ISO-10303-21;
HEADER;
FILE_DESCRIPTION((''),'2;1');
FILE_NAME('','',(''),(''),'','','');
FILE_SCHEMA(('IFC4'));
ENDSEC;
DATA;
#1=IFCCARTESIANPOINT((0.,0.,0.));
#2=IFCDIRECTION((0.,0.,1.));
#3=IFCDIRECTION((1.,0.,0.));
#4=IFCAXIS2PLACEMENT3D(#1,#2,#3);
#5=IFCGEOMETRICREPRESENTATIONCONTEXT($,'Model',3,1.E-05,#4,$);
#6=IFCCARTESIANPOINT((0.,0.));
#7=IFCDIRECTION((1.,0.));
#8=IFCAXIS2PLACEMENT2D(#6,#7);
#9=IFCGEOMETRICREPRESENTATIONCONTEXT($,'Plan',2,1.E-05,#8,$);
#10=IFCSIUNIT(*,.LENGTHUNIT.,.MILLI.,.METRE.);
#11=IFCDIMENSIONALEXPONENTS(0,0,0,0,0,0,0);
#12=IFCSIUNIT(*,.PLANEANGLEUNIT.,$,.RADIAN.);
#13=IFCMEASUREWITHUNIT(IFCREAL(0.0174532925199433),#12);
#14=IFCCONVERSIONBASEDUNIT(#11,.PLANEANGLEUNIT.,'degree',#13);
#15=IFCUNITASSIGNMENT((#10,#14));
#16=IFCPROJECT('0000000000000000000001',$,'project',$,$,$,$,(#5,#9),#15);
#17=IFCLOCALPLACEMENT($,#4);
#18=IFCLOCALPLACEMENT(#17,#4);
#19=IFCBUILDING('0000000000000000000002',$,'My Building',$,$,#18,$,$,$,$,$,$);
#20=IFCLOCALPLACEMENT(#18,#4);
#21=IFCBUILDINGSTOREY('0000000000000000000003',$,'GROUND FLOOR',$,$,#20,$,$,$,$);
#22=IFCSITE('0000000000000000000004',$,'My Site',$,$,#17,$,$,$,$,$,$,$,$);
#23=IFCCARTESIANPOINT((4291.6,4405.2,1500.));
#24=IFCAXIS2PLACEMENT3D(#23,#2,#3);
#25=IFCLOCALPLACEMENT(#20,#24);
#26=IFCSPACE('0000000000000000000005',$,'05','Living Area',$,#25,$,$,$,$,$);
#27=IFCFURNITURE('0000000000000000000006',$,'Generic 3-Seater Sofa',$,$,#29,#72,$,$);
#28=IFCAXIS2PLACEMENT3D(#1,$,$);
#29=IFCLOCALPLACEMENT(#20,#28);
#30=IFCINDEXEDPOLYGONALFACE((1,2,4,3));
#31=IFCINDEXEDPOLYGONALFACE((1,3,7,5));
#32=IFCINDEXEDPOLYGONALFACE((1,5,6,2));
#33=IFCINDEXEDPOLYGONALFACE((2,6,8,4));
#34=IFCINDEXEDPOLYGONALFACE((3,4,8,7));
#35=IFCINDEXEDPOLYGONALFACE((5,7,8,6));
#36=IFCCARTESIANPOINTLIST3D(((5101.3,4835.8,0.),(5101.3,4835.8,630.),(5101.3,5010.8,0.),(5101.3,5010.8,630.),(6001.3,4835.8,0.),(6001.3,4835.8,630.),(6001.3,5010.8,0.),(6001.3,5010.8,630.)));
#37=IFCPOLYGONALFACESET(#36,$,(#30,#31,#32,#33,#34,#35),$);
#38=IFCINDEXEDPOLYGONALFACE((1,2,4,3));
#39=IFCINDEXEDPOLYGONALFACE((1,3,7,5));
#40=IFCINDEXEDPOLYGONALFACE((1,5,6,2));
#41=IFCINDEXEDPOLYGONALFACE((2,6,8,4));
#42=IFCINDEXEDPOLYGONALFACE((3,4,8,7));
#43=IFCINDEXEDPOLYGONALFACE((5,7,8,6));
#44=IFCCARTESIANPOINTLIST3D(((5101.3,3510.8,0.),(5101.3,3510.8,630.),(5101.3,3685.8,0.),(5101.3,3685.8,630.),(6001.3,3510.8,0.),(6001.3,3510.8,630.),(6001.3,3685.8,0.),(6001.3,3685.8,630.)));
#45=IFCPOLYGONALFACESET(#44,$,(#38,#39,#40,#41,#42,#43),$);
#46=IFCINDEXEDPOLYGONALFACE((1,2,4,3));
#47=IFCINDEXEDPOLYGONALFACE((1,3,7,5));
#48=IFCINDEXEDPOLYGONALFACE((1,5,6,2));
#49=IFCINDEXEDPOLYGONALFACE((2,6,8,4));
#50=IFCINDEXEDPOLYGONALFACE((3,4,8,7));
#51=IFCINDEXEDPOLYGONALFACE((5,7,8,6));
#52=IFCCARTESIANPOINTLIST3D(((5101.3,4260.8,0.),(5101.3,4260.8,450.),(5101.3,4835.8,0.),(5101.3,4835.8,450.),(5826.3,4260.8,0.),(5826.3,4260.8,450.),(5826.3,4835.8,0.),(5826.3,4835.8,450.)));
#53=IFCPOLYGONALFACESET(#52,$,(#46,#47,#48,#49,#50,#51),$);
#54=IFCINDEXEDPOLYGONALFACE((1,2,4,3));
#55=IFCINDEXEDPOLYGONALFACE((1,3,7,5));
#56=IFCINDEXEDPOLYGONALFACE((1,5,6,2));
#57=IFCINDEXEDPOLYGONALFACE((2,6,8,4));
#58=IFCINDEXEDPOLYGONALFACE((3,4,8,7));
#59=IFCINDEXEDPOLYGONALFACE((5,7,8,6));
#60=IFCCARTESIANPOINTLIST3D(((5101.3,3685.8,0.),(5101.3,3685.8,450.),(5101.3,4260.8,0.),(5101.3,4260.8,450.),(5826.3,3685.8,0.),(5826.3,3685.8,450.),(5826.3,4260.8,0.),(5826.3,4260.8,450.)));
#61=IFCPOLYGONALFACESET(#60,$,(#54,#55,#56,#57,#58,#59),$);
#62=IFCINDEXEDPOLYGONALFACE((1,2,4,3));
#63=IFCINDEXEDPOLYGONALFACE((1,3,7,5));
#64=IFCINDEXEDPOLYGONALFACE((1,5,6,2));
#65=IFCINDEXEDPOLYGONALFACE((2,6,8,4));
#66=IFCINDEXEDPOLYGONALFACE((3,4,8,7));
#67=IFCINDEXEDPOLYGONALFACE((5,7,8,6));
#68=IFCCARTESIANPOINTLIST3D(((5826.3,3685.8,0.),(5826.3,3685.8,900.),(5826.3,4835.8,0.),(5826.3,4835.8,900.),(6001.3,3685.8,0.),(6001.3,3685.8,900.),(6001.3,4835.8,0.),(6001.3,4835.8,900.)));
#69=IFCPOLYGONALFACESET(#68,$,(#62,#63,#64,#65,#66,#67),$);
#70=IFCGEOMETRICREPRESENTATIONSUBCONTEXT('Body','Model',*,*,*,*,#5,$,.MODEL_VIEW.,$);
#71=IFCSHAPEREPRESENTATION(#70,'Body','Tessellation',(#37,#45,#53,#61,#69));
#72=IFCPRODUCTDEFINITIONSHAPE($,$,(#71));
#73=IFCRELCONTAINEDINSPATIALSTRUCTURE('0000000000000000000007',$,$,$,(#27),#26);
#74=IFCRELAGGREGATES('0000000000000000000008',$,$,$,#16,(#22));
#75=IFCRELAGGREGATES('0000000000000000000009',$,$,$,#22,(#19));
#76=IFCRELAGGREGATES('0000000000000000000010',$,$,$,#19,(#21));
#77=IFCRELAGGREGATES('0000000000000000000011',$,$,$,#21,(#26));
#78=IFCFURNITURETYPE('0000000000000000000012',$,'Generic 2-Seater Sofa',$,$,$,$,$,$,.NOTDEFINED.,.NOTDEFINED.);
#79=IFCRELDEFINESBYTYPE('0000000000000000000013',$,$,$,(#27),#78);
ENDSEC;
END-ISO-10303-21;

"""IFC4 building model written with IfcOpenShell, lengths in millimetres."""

from ifc_helpers import new_model, entity, si_unit, converted_unit, frame, origin_with_axes, origin_2d_with_axis, place, context, subcontext, project, spatial, line, indexed_curve, outline, extrude, shape, source, transform, mapped, type_object, type_shapes, element, save


model = new_model("IFC4")

# Units and contexts
model_context = context("Model", 3, precision=1e-05, world=origin_with_axes())
plan_context = context("Plan", 2, precision=1e-05, world=origin_2d_with_axis())
body_context_1 = subcontext(model_context, "Body", "Model", "MODEL_VIEW")
body_context_2 = subcontext(plan_context, "Body", "Plan", "PLAN_VIEW")
ifc_project = project(units=[si_unit("LENGTHUNIT", "METRE", prefix="MILLI"), converted_unit("PLANEANGLEUNIT", "degree", entity("IfcReal", 0.0174532925199433), si_unit("PLANEANGLEUNIT", "RADIAN"), dimensions=[0, 0, 0, 0, 0, 0, 0])], contexts=[model_context, plan_context])

# Site, building, storey
site_placement = place(None, origin_with_axes())
site = spatial("IfcSite", under=ifc_project, at=site_placement, Name="My Site")
building_placement = place(site_placement, origin_with_axes())
building = spatial("IfcBuilding", under=site, at=building_placement, Name="My Building")
storey_placement = place(building_placement, origin_with_axes())
storey = spatial("IfcBuildingStorey", under=building, at=storey_placement, Name="GROUND FLOOR")

# Shared definitions
space_1_placement = place(storey_placement, frame((4291.6, 4405.2, 1500.0), z_axis=(0.0, 0.0, 1.0), x_axis=(1.0, 0.0, 0.0)))
space_1 = spatial("IfcSpace", under=storey, at=space_1_placement, Name="05", Description="Living Area")

# Furniture
furniture_type_1 = type_object("IfcFurnitureType", Name="Generic 2-Seater Sofa", AssemblyPlace="NOTDEFINED", PredefinedType="NOTDEFINED")
shared_shape_1 = source(origin_with_axes(), body_context_1, "Body", "SweptSolid", [
    extrude(outline(indexed_curve([(0.0, 0.0), (175.0, 0.0), (175.0, 900.0), (0.0, 900.0)], segments=[line(1, 2, 3, 4, 1)])), frame((-750.0, -900.0, 0.0), z_axis=(0.0, 0.0, 1.0), x_axis=(1.0, 0.0, 0.0)), (0.0, 0.0, 1.0), 630.0),
    extrude(outline(indexed_curve([(0.0, 0.0), (175.0, 0.0), (175.0, 900.0), (0.0, 900.0)], segments=[line(1, 2, 3, 4, 1)])), frame((575.0, -900.0, 0.0), z_axis=(0.0, 0.0, 1.0), x_axis=(1.0, 0.0, 0.0)), (0.0, 0.0, 1.0), 630.0),
    extrude(outline(indexed_curve([(175.0, 0.0), (750.0, 0.0), (750.0, 725.0), (175.0, 725.0)], segments=[line(1, 2, 3, 4, 1)])), frame((-750.0, -900.0, 0.0), z_axis=(0.0, 0.0, 1.0), x_axis=(1.0, 0.0, 0.0)), (0.0, 0.0, 1.0), 450.0),
    extrude(outline(indexed_curve([(750.0, 0.0), (1325.0, 0.0), (1325.0, 725.0), (750.0, 725.0)], segments=[line(1, 2, 3, 4, 1)])), frame((-750.0, -900.0, 0.0), z_axis=(0.0, 0.0, 1.0), x_axis=(1.0, 0.0, 0.0)), (0.0, 0.0, 1.0), 450.0),
    extrude(outline(indexed_curve([(175.0, 725.0), (1325.0, 725.0), (1325.0, 900.0), (175.0, 900.0)], segments=[line(1, 2, 3, 4, 1)])), frame((-750.0, -900.0, 0.0), z_axis=(0.0, 0.0, 1.0), x_axis=(1.0, 0.0, 0.0)), (0.0, 0.0, 1.0), 900.0),
])
shared_shape_2 = source(origin_with_axes(), body_context_2, "Body", "Curve2D", [
    entity("IfcIndexedPolyCurve", entity("IfcCartesianPointList2D", [[-750.0, -900.0], [-575.0, -900.0], [-575.0, 0.0], [-750.0, 0.0]]), [entity("IfcLineIndex", [1, 2, 3, 4, 1])]),
    entity("IfcIndexedPolyCurve", entity("IfcCartesianPointList2D", [[575.0, -900.0], [750.0, -900.0], [750.0, 0.0], [575.0, 0.0]]), [entity("IfcLineIndex", [1, 2, 3, 4, 1])]),
    entity("IfcIndexedPolyCurve", entity("IfcCartesianPointList2D", [[-575.0, -900.0], [0.0, -900.0], [0.0, -175.0], [-575.0, -175.0]]), [entity("IfcLineIndex", [1, 2, 3, 4, 1])]),
    entity("IfcIndexedPolyCurve", entity("IfcCartesianPointList2D", [[0.0, -900.0], [575.0, -900.0], [575.0, -175.0], [0.0, -175.0]]), [entity("IfcLineIndex", [1, 2, 3, 4, 1])]),
    entity("IfcIndexedPolyCurve", entity("IfcCartesianPointList2D", [[-575.0, -175.0], [575.0, -175.0], [575.0, 0.0], [-575.0, 0.0]]), [entity("IfcLineIndex", [1, 2, 3, 4, 1])]),
])
type_shapes(furniture_type_1, [shared_shape_1, shared_shape_2])
furniture_1_placement = place(space_1_placement, frame((1709.7, -144.4, -1500.0), z_axis=(0.0, 0.0, 1.0), x_axis=(0.0, -1.0, 0.0)))
element("IfcFurniture", 1, at=furniture_1_placement, inside=space_1, type_object=furniture_type_1, Name="Generic 3-Seater Sofa", shapes=[
    shape(body_context_1, "Body", "MappedRepresentation", [mapped(shared_shape_1, transform((0.0, 0.0, 0.0), x_axis=(1.0, 0.0, 0.0), y_axis=(0.0, 1.0, 0.0), z_axis=(0.0, 0.0, 1.0), scale=1.0))]),
    shape(body_context_2, "Body", "MappedRepresentation", [mapped(shared_shape_2, transform((0.0, 0.0, 0.0), x_axis=(1.0, 0.0, 0.0), y_axis=(0.0, 1.0, 0.0), z_axis=(0.0, 0.0, 1.0), scale=1.0))]),
])

save(model, "model.ifc")
